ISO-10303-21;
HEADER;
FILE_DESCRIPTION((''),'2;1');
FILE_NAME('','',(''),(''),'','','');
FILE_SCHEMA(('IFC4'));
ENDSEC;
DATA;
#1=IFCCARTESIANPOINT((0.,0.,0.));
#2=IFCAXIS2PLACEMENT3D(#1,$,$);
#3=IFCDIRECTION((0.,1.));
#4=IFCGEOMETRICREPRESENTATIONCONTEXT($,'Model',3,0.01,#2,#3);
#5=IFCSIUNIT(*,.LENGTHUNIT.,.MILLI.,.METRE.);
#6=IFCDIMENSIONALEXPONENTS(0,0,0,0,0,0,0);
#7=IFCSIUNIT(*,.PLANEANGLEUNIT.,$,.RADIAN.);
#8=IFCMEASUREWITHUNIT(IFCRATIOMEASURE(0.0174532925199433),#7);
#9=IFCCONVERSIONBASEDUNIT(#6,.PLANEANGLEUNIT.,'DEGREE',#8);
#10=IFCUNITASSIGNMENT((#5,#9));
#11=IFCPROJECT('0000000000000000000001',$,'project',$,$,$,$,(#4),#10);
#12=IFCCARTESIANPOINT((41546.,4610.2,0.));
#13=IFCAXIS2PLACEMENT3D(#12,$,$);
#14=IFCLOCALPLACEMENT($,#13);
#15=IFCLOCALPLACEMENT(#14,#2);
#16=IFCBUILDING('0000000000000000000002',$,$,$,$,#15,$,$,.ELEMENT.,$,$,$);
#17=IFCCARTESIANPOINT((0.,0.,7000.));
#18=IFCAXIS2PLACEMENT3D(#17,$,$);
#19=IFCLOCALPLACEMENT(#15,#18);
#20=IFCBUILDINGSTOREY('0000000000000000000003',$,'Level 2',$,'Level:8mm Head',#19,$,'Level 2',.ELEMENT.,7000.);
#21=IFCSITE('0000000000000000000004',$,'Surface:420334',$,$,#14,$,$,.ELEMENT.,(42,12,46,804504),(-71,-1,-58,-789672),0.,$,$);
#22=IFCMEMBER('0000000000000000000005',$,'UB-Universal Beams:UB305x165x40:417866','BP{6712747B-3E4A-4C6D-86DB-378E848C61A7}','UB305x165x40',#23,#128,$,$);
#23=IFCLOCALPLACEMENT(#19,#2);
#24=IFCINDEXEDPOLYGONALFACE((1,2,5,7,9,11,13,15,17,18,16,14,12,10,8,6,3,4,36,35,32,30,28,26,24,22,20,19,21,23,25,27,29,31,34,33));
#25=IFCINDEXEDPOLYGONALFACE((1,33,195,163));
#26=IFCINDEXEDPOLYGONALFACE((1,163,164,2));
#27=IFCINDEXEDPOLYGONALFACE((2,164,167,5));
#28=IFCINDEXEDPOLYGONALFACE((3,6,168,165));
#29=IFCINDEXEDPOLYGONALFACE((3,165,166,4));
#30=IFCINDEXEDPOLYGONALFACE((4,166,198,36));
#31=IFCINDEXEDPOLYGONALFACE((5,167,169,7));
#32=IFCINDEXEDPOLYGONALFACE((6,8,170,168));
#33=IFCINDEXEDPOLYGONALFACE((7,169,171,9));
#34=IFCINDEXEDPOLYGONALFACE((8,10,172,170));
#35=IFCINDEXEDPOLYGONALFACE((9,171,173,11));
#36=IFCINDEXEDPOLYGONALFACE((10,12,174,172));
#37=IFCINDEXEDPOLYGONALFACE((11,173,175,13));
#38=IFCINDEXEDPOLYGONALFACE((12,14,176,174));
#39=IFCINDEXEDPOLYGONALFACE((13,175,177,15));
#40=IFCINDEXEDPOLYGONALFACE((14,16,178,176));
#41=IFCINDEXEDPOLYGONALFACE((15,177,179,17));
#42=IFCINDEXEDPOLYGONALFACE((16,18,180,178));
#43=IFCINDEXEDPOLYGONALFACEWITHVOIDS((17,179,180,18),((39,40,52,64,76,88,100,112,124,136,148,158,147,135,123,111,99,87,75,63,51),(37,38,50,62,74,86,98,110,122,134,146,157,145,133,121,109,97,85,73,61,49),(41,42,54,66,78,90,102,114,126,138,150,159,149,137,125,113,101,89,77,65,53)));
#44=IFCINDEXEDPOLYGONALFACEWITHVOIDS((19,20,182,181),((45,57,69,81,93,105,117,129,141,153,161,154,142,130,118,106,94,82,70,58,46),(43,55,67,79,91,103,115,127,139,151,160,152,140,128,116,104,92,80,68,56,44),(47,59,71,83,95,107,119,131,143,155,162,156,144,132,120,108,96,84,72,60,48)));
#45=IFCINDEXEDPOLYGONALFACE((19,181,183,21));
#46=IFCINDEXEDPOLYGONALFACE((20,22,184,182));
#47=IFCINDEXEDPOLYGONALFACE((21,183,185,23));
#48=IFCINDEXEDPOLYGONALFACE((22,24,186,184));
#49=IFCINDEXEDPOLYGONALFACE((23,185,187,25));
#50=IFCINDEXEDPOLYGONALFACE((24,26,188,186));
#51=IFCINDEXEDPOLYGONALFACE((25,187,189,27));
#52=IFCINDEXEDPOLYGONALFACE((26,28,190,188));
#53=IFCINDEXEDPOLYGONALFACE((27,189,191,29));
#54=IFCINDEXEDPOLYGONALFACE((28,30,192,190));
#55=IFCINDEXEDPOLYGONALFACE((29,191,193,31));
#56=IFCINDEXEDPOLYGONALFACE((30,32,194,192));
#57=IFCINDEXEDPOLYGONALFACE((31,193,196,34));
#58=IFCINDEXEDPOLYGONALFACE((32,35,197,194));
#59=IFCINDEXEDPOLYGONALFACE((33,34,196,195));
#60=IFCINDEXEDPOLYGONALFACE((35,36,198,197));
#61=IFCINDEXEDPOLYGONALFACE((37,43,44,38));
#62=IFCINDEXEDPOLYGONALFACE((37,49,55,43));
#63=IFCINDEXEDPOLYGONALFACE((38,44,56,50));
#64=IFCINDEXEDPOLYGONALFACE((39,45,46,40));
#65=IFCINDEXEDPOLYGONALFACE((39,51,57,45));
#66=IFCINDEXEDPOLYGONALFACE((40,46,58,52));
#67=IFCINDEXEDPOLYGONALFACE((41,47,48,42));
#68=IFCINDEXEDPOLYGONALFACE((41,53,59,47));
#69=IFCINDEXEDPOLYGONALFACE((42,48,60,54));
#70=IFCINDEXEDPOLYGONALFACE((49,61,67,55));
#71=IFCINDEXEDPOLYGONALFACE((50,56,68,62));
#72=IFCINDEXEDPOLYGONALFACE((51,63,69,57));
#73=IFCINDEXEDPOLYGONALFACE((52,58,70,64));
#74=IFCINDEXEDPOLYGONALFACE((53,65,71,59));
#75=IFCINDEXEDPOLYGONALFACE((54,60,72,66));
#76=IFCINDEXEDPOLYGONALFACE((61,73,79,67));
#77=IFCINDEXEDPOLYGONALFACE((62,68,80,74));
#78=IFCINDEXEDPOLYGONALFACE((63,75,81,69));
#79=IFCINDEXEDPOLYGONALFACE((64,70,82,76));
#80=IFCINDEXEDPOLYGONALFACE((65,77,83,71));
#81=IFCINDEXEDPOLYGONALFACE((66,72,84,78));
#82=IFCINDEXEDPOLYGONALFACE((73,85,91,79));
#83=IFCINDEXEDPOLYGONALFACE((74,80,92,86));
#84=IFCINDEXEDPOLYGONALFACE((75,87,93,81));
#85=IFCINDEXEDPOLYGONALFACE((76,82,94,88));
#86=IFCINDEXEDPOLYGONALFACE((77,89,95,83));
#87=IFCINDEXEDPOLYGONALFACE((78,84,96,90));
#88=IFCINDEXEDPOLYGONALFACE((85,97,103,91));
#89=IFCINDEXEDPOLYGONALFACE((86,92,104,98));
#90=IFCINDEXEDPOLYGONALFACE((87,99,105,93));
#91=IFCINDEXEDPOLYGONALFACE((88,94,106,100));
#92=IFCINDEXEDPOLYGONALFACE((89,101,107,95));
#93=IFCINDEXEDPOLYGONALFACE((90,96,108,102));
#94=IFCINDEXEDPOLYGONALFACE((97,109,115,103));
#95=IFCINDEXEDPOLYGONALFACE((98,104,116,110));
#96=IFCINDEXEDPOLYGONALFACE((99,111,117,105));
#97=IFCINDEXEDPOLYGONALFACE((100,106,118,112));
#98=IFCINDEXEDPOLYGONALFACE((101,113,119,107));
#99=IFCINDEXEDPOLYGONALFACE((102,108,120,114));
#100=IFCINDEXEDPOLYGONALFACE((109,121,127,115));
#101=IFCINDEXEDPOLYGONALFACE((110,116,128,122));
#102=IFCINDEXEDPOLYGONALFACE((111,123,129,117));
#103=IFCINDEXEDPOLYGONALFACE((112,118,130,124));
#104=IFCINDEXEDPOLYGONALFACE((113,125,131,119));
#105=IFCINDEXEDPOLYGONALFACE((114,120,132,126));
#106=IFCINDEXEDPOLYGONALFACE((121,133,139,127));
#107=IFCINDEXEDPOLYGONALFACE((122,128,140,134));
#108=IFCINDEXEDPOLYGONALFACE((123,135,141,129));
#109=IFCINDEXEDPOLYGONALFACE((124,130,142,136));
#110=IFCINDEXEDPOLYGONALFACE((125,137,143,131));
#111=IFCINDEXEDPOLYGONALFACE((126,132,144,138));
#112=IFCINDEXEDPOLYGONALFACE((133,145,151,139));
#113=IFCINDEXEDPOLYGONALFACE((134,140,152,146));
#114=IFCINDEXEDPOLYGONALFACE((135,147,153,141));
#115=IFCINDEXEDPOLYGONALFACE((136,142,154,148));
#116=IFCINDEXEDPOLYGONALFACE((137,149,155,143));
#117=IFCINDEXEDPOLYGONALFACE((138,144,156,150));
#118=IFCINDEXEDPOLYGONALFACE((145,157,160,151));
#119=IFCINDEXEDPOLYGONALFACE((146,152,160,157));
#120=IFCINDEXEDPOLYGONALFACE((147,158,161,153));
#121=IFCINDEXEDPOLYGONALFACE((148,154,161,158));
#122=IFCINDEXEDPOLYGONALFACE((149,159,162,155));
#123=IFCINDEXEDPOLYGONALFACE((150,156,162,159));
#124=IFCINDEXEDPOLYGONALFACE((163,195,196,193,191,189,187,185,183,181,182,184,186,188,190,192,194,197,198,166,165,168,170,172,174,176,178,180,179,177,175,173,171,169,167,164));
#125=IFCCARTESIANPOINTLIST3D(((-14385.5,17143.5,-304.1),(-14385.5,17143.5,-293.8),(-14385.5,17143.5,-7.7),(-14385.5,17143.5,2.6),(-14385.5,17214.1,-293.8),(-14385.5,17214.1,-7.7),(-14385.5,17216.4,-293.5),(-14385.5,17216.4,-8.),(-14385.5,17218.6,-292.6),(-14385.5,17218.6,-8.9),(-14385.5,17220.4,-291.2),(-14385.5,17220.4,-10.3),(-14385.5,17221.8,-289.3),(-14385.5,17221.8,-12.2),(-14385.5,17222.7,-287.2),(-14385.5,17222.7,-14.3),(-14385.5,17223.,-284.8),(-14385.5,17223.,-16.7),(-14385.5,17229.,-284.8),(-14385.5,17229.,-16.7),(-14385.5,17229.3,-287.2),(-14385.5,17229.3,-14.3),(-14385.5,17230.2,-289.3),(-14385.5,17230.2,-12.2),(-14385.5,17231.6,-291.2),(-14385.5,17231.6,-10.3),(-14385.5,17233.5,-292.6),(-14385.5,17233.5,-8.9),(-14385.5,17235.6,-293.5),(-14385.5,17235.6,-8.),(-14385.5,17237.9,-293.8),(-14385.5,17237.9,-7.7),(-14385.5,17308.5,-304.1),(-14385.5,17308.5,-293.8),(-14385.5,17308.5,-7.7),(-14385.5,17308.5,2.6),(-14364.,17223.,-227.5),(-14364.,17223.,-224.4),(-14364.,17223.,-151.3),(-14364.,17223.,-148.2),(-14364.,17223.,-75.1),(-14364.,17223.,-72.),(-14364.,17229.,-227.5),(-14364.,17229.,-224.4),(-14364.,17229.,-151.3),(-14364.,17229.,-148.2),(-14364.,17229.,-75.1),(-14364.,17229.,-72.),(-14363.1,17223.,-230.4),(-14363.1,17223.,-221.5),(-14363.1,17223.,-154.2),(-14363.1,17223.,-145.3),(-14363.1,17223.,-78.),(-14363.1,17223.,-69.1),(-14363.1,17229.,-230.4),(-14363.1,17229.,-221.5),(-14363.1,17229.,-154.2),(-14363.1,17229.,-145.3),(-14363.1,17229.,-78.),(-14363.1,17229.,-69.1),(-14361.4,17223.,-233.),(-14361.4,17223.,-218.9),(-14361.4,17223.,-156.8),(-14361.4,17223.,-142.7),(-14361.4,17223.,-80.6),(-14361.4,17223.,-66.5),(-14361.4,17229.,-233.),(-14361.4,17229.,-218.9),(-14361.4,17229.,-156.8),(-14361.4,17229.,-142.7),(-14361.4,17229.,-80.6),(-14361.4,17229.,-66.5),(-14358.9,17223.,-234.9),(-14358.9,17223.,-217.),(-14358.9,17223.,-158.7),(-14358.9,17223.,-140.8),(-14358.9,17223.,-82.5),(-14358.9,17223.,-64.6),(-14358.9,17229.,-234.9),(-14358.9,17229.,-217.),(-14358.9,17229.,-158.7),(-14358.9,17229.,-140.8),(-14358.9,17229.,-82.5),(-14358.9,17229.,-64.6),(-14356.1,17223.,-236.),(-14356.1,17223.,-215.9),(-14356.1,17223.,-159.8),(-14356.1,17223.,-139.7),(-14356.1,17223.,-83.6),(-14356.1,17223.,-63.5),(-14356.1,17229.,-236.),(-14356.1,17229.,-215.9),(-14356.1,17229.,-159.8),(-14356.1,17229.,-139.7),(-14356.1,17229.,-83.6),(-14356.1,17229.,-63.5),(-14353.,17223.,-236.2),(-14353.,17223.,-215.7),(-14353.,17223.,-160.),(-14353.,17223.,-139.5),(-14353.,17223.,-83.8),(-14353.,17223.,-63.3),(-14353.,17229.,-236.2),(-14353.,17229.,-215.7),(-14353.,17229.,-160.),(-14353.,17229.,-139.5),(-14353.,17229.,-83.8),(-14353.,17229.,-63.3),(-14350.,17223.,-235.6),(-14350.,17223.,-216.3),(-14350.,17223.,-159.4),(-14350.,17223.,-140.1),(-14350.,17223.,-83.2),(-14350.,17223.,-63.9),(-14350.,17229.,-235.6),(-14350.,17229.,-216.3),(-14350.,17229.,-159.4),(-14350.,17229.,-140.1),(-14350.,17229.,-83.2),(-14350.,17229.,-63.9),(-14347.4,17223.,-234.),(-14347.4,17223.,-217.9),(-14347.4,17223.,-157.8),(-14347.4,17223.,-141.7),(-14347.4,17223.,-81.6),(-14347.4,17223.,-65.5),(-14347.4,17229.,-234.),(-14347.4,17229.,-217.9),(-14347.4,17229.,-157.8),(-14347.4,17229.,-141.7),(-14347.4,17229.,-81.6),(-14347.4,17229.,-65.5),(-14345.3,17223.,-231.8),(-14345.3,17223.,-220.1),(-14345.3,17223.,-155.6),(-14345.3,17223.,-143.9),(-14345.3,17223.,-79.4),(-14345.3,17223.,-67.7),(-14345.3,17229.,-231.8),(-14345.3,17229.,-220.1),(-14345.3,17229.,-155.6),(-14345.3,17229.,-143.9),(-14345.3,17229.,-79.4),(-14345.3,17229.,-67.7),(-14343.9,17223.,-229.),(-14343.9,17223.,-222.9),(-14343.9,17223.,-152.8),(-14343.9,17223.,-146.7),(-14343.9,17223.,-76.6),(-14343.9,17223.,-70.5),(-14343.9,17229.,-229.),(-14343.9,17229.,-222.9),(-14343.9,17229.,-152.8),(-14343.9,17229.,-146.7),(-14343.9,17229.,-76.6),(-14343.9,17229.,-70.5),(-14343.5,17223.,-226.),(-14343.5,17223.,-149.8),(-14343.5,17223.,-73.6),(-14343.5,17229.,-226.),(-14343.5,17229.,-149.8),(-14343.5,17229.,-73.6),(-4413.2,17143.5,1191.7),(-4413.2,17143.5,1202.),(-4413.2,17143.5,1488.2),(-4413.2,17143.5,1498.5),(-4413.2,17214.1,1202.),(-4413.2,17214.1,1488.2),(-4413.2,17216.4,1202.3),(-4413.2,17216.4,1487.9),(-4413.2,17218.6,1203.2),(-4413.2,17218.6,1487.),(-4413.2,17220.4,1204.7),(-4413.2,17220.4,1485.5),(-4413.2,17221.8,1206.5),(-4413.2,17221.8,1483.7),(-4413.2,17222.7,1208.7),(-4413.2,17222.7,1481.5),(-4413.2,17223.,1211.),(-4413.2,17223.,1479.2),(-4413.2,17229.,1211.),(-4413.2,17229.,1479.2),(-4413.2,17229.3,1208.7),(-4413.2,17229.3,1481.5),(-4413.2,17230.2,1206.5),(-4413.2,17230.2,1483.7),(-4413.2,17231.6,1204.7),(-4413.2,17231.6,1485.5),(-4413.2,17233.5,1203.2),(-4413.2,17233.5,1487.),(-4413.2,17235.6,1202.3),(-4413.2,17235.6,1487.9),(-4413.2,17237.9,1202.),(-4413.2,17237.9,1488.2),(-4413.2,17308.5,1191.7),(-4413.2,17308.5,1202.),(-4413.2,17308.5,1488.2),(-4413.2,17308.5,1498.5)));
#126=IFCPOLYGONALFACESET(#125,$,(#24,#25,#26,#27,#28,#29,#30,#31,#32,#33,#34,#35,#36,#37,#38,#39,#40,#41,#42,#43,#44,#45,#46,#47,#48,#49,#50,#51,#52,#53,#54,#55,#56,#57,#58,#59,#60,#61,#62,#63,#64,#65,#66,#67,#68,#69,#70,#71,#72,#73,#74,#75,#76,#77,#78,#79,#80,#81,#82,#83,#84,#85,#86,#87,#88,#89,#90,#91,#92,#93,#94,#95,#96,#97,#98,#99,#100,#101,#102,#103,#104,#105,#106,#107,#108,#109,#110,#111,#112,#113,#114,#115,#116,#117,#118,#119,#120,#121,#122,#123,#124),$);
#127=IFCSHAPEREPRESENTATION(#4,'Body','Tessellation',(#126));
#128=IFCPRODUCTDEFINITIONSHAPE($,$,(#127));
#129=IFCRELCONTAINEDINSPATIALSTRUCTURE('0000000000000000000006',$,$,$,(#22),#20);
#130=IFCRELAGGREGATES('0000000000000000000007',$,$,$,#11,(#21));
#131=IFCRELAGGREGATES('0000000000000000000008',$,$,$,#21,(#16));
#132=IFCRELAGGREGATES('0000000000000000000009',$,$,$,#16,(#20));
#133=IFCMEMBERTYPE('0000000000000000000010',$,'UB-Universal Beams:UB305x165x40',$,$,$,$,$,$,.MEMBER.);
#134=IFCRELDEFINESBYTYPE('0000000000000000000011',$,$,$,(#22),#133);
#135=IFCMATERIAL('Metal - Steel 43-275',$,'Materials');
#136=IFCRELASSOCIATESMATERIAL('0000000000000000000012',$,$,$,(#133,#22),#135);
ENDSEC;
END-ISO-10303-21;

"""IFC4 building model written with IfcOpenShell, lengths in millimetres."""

from ifc_helpers import new_model, entity, si_unit, converted_unit, direction, frame, frame_2d, origin, origin_2d, origin_2d_with_axis, place, context, project, spatial, circle, i_section, extrude, clip, halfspace, material, type_object, element, save


model = new_model("IFC4")

# Units and contexts
model_context = context("Model", 3, precision=0.01, world=origin(), true_north=direction((0.0, 1.0)))
ifc_project = project(units=[si_unit("LENGTHUNIT", "METRE", prefix="MILLI"), converted_unit("PLANEANGLEUNIT", "DEGREE", entity("IfcRatioMeasure", 0.0174532925199433), si_unit("PLANEANGLEUNIT", "RADIAN"), dimensions=[0, 0, 0, 0, 0, 0, 0])], contexts=[model_context])

# Site, building, storey
site_placement = place(None, frame((41546.0, 4610.2, 0.0)))
site = spatial("IfcSite", under=ifc_project, at=site_placement, Name="Surface:420334", CompositionType="ELEMENT", RefLatitude=(42, 12, 46, 804504), RefLongitude=(-71, -1, -58, -789672), RefElevation=0.0)
building_placement = place(site_placement, origin())
building = spatial("IfcBuilding", under=site, at=building_placement, CompositionType="ELEMENT")
storey_placement = place(building_placement, frame((0.0, 0.0, 7000.0)))
storey = spatial("IfcBuildingStorey", under=building, at=storey_placement, Name="Level 2", ObjectType="Level:8mm Head", LongName="Level 2", CompositionType="ELEMENT", Elevation=7000.0)

# Shared definitions
ifc_material = material(Name="Metal - Steel 43-275", Category="Materials")

# Member, openings
member_type_1 = type_object("IfcMemberType", Name="UB-Universal Beams:UB305x165x40", PredefinedType="MEMBER", material=ifc_material)
member_1_placement = place(storey_placement, frame((-14856.8, 17226.0, -221.4), z_axis=(-0.988936, 0.0, -0.14834), x_axis=(0.0, -1.0, 0.0)))
member_1 = element("IfcMember", 1, at=member_1_placement, inside=storey, type_object=member_type_1, material=ifc_material, Name="UB-Universal Beams:UB305x165x40:417866", Description="BP{6712747B-3E4A-4C6D-86DB-378E848C61A7}", ObjectType="UB305x165x40", context=model_context, shape_type="Clipping", body=[
    clip(clip(extrude(i_section(OverallWidth=165.0, OverallDepth=303.4, WebThickness=6.0, FlangeThickness=10.2, FilletRadius=8.9, at=origin_2d()), origin(), (0.0, 0.0, -1.0), 11074.7), halfspace(frame((17226.0, -8252.8, -9322.5), z_axis=(0.0, 0.14834, 0.988936), x_axis=(1.0, 0.0, 0.0)), True)), halfspace(frame((17226.0, -6773.5, 539.5), z_axis=(0.0, -0.14834, -0.988936), x_axis=(-1.0, 0.0, 0.0)), True)),
])
opening_1_placement = place(member_1_placement, frame((3.5, -3.7, -508.0), z_axis=(-1.0, 0.0, 0.0), x_axis=(0.0, -0.14834, -0.988936)))
element("IfcOpeningElement", 2, at=opening_1_placement, cuts=member_1, ObjectType="Opening", context=model_context, shape_type="SweptSolid", body=[
    extrude(circle(Radius=10.3, at=origin_2d_with_axis()), origin(), (0.0, 0.0, 1.0), 7.0),
])
opening_2_placement = place(member_1_placement, frame((3.5, -3.7, -508.0), z_axis=(-1.0, 0.0, 0.0), x_axis=(0.0, -0.14834, -0.988936)))
element("IfcOpeningElement", 3, at=opening_2_placement, cuts=member_1, ObjectType="Opening", context=model_context, shape_type="SweptSolid", body=[
    extrude(circle(Radius=10.3, at=frame_2d((0.0, 76.2), x_axis=(1.0, 0.0))), origin(), (0.0, 0.0, 1.0), 7.0),
])
opening_3_placement = place(member_1_placement, frame((3.5, -3.7, -508.0), z_axis=(-1.0, 0.0, 0.0), x_axis=(0.0, -0.14834, -0.988936)))
element("IfcOpeningElement", 4, at=opening_3_placement, cuts=member_1, ObjectType="Opening", context=model_context, shape_type="SweptSolid", body=[
    extrude(circle(Radius=10.3, at=frame_2d((0.0, -76.2), x_axis=(1.0, 0.0))), origin(), (0.0, 0.0, 1.0), 7.0),
])

save(model, "model.ifc")
